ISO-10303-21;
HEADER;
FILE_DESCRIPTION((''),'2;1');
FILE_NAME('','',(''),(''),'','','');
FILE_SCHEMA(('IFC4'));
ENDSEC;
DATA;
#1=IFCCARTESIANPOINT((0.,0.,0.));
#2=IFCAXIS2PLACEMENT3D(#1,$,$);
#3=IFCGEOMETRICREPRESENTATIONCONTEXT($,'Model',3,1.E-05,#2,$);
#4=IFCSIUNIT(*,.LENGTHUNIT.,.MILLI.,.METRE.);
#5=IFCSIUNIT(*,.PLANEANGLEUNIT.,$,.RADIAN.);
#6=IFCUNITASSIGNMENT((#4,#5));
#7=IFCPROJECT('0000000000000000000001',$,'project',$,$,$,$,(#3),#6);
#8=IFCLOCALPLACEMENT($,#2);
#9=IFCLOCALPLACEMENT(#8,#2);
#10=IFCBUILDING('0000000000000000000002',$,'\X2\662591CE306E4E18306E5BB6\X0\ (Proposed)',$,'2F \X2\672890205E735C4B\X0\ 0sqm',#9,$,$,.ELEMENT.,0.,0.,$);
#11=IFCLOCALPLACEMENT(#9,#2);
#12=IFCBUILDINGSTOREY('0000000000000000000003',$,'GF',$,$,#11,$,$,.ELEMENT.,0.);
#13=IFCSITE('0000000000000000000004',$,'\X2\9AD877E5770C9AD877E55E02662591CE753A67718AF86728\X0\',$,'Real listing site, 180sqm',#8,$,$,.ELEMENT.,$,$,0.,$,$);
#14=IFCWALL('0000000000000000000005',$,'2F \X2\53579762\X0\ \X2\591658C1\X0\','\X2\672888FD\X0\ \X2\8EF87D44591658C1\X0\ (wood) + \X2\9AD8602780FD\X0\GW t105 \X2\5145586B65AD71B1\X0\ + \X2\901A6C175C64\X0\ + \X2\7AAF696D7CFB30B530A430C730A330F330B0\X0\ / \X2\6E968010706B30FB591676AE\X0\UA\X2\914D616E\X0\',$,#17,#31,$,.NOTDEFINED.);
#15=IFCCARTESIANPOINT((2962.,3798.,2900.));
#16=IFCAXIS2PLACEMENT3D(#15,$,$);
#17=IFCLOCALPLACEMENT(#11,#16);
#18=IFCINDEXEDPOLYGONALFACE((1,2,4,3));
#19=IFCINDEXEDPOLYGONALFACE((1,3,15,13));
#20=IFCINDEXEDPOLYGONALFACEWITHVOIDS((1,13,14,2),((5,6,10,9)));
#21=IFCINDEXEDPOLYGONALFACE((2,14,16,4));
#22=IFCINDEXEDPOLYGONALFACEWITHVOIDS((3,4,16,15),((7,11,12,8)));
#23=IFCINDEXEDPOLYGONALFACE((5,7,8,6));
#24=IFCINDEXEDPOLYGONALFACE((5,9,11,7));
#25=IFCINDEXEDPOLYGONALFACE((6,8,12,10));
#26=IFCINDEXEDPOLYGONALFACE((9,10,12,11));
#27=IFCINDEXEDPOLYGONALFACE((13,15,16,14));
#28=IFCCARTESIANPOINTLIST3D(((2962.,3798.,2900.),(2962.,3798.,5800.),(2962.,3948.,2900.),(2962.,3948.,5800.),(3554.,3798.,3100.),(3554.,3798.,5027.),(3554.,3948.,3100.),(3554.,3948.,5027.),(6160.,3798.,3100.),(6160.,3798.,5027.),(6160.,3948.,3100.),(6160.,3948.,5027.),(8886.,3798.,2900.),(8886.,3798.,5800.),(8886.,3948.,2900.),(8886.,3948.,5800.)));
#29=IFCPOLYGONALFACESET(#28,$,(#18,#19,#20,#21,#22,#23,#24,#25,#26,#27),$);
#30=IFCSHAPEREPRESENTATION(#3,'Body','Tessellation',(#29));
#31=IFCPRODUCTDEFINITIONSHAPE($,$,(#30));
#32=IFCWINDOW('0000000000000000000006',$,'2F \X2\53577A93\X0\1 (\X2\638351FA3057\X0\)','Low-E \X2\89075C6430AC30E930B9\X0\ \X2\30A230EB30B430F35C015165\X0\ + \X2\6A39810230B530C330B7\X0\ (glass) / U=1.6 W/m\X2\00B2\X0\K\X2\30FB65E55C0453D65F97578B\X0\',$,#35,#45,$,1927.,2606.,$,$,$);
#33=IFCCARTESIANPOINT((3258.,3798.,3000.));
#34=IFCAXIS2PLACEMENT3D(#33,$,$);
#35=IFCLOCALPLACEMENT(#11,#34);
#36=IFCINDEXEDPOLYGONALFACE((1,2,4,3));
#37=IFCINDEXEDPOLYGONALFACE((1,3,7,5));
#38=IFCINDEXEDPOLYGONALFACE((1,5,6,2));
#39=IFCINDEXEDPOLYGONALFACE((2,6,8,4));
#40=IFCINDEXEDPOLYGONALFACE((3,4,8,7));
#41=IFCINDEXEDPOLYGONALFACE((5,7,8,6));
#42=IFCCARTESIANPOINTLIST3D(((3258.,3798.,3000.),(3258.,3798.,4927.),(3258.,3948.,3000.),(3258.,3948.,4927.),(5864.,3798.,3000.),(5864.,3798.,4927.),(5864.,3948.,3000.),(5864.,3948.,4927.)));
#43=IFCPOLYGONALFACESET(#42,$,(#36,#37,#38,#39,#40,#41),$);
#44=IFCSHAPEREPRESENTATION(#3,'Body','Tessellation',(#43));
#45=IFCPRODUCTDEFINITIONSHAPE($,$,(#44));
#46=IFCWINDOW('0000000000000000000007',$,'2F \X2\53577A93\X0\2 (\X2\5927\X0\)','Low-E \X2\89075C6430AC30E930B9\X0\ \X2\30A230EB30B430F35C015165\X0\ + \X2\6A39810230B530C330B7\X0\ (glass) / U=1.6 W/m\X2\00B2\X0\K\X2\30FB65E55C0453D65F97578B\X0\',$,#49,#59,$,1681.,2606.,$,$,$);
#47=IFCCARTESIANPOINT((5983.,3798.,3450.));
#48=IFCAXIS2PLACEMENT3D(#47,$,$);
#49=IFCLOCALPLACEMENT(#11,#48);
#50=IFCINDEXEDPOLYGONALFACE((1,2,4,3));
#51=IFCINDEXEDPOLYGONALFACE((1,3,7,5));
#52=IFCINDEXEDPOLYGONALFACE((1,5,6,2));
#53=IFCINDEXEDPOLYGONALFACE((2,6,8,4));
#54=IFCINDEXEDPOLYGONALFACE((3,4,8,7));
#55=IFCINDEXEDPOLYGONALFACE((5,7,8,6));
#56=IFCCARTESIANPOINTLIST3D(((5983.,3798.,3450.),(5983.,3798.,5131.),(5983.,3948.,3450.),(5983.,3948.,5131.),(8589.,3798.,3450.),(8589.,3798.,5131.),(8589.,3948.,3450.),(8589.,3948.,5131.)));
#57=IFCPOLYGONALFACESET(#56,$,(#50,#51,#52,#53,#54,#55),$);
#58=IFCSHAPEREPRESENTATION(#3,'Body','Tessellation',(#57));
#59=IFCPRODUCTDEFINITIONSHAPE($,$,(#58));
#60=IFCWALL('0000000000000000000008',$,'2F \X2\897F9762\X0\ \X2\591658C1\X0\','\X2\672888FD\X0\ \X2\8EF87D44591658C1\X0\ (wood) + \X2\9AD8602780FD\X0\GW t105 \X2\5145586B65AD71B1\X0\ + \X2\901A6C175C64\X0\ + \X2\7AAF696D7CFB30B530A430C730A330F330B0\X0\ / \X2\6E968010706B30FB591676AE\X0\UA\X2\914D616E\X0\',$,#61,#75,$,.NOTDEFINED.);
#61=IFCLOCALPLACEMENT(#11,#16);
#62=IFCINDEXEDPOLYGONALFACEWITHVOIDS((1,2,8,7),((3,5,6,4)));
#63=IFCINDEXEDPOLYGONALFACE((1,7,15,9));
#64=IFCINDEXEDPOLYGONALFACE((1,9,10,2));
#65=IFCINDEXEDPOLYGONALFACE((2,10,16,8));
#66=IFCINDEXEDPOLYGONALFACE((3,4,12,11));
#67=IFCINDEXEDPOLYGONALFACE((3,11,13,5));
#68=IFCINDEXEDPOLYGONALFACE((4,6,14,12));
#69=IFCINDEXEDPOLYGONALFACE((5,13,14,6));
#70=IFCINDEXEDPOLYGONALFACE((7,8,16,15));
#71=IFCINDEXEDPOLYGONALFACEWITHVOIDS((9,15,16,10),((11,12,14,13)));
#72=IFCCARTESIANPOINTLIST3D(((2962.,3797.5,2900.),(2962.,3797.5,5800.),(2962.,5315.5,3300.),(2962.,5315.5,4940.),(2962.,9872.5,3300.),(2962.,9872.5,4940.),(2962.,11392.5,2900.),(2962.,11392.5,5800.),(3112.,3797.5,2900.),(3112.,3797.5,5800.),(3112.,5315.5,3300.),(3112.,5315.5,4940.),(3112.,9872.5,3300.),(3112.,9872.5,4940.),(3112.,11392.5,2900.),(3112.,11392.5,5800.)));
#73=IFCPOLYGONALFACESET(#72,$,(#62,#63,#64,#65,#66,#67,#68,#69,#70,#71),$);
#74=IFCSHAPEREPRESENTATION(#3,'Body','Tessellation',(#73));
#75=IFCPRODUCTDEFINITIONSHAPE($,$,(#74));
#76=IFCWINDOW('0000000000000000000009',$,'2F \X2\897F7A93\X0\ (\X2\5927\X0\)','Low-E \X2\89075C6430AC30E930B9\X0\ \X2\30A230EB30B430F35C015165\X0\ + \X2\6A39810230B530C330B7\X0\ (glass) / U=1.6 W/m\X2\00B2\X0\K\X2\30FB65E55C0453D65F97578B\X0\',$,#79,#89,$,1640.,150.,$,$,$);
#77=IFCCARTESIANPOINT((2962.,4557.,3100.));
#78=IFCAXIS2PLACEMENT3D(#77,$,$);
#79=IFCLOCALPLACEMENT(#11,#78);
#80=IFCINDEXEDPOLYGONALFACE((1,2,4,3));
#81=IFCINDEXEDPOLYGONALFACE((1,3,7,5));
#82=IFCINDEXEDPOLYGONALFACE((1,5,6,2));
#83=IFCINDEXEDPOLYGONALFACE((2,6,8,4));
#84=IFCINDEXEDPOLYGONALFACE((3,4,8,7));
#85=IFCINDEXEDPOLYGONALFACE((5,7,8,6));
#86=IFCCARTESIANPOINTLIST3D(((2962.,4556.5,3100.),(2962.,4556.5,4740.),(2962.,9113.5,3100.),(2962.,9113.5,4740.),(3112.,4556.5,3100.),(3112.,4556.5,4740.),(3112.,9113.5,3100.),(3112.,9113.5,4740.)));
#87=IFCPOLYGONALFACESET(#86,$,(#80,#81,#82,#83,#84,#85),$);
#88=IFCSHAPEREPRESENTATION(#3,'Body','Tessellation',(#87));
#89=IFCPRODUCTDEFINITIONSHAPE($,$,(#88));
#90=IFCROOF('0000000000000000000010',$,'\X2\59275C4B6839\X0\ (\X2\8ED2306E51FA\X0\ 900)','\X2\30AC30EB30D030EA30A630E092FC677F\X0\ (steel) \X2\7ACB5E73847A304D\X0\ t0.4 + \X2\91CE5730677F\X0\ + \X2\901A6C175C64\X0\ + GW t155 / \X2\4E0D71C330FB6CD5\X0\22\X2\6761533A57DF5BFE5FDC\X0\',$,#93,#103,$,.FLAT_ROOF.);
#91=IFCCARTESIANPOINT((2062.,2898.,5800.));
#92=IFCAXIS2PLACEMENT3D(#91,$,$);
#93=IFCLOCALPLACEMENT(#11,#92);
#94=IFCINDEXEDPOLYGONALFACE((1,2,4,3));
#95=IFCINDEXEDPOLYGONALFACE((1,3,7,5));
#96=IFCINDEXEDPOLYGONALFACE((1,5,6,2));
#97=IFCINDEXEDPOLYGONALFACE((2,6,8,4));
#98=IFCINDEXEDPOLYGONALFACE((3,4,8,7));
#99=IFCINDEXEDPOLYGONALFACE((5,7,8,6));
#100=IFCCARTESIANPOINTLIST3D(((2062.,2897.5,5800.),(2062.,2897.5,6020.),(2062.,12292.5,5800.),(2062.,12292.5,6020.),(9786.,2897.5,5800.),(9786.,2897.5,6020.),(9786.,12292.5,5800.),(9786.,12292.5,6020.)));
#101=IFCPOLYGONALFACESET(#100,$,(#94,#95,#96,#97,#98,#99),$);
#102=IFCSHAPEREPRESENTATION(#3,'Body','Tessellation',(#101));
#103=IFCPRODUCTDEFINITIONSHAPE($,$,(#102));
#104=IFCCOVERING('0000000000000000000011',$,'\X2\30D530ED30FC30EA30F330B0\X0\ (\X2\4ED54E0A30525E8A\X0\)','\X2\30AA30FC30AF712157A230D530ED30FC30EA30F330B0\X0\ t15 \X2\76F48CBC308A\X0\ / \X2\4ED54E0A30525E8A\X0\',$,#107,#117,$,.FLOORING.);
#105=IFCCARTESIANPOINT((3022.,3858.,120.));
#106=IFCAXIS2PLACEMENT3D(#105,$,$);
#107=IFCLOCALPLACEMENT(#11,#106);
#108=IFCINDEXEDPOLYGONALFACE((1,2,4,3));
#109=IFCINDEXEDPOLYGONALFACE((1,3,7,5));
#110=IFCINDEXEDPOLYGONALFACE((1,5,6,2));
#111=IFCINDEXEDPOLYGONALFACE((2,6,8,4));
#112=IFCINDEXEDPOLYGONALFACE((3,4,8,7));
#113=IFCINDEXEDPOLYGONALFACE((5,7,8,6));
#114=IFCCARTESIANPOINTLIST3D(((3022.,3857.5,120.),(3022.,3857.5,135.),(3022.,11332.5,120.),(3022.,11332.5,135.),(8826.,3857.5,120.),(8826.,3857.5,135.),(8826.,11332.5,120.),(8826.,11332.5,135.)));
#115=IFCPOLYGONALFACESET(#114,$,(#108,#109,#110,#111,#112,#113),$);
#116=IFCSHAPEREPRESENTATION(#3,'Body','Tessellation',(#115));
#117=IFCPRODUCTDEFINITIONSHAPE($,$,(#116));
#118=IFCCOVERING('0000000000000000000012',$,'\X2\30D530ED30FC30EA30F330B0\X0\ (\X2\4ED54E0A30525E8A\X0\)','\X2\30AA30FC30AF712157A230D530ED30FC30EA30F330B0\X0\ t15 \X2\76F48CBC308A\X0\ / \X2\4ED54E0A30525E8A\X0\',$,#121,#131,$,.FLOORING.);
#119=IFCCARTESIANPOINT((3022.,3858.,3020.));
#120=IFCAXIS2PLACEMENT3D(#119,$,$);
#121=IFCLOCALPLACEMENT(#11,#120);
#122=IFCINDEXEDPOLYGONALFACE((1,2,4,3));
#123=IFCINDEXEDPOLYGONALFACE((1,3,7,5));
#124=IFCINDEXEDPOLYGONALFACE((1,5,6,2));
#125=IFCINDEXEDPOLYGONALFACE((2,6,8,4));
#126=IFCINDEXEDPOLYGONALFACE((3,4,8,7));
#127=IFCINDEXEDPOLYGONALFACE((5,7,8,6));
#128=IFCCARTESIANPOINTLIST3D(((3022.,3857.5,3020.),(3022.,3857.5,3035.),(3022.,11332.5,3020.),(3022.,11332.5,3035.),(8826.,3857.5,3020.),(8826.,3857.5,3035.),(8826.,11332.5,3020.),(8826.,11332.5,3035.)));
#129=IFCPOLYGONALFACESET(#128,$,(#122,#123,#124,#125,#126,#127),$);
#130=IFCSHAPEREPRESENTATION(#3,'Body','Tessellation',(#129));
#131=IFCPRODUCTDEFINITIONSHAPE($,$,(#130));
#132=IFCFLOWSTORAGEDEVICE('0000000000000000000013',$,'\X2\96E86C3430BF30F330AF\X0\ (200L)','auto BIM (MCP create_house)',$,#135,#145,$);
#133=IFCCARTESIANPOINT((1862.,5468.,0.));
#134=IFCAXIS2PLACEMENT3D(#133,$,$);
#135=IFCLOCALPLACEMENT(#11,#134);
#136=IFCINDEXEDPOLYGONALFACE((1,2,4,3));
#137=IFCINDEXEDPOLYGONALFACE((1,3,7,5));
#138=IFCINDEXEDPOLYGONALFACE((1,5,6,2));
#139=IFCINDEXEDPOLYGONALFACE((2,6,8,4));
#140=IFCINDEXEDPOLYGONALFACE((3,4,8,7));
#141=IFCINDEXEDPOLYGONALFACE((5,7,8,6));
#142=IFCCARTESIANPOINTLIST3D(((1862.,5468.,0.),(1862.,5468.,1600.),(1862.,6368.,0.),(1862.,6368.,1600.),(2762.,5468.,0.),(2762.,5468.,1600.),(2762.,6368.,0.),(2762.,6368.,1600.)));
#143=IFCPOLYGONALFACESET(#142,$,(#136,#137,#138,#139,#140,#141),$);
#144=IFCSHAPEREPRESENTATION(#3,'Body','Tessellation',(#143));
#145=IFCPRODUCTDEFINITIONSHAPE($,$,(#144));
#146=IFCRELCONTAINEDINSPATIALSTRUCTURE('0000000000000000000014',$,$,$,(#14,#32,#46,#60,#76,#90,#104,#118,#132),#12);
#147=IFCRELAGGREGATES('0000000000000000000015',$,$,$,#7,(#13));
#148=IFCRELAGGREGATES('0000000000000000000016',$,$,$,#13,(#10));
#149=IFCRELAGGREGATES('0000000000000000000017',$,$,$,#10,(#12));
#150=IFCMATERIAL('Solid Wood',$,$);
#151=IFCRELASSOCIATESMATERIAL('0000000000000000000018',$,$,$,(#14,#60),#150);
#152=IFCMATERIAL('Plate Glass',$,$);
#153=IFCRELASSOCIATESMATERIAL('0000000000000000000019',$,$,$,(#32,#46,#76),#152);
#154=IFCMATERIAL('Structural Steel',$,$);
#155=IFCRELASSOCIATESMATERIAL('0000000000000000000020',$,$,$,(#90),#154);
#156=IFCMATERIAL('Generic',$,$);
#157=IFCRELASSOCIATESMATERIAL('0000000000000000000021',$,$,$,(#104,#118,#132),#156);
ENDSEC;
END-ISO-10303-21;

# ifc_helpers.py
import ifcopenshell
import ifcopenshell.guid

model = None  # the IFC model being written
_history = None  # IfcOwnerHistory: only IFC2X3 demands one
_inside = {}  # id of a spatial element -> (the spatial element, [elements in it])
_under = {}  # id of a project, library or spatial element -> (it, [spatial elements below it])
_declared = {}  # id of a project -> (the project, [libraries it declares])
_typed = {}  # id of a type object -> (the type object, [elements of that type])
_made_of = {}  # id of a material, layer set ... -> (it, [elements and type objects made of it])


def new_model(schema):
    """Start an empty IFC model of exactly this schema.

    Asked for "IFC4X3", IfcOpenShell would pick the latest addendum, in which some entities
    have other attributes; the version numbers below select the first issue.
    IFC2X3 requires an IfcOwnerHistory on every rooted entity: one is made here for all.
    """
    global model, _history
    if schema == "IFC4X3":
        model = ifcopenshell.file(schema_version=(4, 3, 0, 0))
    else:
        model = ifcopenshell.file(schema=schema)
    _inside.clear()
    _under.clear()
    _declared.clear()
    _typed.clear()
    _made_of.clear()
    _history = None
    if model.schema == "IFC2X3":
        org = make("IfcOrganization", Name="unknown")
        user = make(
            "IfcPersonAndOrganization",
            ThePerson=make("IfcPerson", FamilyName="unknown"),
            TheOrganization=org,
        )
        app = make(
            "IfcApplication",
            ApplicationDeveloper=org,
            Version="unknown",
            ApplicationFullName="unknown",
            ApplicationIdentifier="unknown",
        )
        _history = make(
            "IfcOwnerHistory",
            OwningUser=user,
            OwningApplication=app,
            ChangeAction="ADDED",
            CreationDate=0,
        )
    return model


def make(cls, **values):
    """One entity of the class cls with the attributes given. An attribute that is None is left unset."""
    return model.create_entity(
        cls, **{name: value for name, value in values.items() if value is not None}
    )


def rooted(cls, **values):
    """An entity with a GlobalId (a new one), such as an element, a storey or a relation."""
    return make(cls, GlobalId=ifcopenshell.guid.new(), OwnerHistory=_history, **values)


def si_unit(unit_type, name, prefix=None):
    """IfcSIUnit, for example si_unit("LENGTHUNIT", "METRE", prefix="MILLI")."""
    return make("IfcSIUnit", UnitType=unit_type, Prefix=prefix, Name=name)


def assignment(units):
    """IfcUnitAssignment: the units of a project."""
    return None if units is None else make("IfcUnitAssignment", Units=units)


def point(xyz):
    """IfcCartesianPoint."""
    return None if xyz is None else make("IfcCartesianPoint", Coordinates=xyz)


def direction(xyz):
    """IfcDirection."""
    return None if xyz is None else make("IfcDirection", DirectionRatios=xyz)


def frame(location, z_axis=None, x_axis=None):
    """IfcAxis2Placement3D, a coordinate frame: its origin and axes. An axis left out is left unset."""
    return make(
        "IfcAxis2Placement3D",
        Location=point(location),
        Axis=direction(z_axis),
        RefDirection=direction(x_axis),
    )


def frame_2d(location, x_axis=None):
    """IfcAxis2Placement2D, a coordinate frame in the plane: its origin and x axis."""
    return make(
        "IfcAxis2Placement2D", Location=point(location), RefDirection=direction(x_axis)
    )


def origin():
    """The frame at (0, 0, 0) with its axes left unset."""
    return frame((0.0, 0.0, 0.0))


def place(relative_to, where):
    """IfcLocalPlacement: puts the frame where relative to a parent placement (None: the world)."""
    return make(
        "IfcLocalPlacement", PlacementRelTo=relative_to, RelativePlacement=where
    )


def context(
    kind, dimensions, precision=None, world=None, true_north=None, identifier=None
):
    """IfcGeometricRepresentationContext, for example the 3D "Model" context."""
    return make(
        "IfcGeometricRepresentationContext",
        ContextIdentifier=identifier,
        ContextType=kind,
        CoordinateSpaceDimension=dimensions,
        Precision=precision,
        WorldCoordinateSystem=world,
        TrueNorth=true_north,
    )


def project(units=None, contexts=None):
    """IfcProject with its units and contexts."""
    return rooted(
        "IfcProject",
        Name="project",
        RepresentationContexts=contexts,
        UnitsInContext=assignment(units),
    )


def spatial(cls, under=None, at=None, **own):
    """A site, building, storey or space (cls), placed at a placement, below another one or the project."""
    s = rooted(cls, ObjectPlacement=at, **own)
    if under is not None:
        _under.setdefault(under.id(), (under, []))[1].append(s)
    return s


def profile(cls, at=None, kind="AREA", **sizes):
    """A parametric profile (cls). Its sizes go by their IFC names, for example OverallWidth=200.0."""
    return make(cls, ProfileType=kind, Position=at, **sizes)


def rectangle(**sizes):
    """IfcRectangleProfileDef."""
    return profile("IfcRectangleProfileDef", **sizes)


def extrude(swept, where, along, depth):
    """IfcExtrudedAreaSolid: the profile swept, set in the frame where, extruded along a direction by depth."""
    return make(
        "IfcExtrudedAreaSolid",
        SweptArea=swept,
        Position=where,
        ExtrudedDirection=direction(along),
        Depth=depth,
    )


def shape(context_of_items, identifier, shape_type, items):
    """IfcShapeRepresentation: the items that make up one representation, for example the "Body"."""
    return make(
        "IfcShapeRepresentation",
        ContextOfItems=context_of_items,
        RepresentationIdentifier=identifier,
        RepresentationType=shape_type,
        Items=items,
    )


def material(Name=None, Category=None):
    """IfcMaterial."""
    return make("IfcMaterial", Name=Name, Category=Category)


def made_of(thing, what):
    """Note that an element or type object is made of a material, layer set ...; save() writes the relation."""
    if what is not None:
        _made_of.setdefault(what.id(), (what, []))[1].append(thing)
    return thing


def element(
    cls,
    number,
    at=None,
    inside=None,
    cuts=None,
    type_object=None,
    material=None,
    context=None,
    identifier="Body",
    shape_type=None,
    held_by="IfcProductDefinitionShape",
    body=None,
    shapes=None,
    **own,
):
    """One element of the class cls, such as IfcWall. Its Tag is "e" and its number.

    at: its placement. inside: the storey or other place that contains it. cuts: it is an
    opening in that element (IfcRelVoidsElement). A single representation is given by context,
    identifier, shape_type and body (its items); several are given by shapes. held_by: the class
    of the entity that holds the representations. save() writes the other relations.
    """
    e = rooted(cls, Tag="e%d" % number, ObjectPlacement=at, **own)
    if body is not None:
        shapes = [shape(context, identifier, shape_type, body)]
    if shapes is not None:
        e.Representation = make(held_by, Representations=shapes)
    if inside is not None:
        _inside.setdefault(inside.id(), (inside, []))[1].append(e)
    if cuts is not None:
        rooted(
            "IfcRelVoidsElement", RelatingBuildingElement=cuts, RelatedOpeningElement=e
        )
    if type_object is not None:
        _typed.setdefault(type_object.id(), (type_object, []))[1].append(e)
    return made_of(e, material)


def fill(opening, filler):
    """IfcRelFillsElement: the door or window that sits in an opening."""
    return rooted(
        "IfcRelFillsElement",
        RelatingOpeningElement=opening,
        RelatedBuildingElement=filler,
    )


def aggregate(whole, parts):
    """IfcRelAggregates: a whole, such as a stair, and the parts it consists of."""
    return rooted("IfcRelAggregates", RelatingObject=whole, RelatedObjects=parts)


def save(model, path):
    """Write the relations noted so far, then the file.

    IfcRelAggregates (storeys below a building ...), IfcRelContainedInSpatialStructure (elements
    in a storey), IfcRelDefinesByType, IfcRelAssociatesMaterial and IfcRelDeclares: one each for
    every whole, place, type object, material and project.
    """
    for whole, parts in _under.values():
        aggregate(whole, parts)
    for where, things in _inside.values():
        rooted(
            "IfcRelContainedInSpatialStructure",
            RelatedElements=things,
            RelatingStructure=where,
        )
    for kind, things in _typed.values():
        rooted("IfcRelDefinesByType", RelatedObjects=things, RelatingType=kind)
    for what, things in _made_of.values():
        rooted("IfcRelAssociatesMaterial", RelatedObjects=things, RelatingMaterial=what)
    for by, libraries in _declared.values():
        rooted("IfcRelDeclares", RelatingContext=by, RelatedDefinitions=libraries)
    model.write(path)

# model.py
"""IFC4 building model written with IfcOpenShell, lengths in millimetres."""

from ifc_helpers import new_model, si_unit, frame, frame_2d, origin, place, context, project, spatial, rectangle, extrude, material, element, fill, save


model = new_model("IFC4")

# Units and contexts
model_context = context("Model", 3, precision=1e-05, world=origin())
ifc_project = project(units=[si_unit("LENGTHUNIT", "METRE", prefix="MILLI"), si_unit("PLANEANGLEUNIT", "RADIAN")], contexts=[model_context])

# Site, building, storey
site_placement = place(None, origin())
site = spatial("IfcSite", under=ifc_project, at=site_placement, Name="高知県高知市春野町東諸木", ObjectType="Real listing site, 180sqm", CompositionType="ELEMENT", RefElevation=0.0)
building_placement = place(site_placement, origin())
building = spatial("IfcBuilding", under=site, at=building_placement, Name="春野の丘の家 (Proposed)", ObjectType="2F 木造平屋 0sqm", CompositionType="ELEMENT", ElevationOfRefHeight=0.0, ElevationOfTerrain=0.0)
storey_placement = place(building_placement, origin())
storey = spatial("IfcBuildingStorey", under=building, at=storey_placement, Name="GF", CompositionType="ELEMENT", Elevation=0.0)

# Shared definitions
ifc_material_1 = material(Name="Solid Wood")

# Shared definitions
ifc_material_2 = material(Name="Plate Glass")

# Wall, openings, windows
wall_1_placement = place(storey_placement, frame((2962.0, 3798.0, 2900.0)))
wall_1 = element("IfcWall", 1, at=wall_1_placement, inside=storey, material=ifc_material_1, Name="2F 南面 外壁", Description="木製 軸組外壁 (wood) + 高性能GW t105 充填断熱 + 通気層 + 窯業系サイディング / 準耐火・外皮UA配慮", PredefinedType="NOTDEFINED", context=model_context, shape_type="SweptSolid", body=[
    extrude(rectangle(XDim=5924.0, YDim=150.0, at=frame_2d((2962.0, 75.0))), frame((2962.0, 3798.0, 2900.0)), (0.0, 0.0, 1.0), 2900.0),
])
opening_1_placement = place(storey_placement, frame((3258.0, 3798.0, 3000.0)))
opening_1 = element("IfcOpeningElement", 2, at=opening_1_placement, cuts=wall_1, PredefinedType="NOTDEFINED", context=model_context, shape_type="SweptSolid", body=[
    extrude(rectangle(XDim=2606.0, YDim=150.0, at=frame_2d((1303.0, 75.0))), frame((3258.0, 3798.0, 3000.0)), (0.0, 0.0, 1.0), 1927.0),
])
opening_2_placement = place(storey_placement, frame((5983.0, 3798.0, 3450.0)))
opening_2 = element("IfcOpeningElement", 3, at=opening_2_placement, cuts=wall_1, PredefinedType="NOTDEFINED", context=model_context, shape_type="SweptSolid", body=[
    extrude(rectangle(XDim=2606.0, YDim=150.0, at=frame_2d((1303.0, 75.0))), frame((5983.0, 3798.0, 3450.0)), (0.0, 0.0, 1.0), 1681.0),
])
window_1_placement = place(storey_placement, frame((3258.0, 3798.0, 3000.0)))
window_1 = element("IfcWindow", 4, at=window_1_placement, inside=storey, material=ifc_material_2, Name="2F 南窓1 (掃出し)", Description="Low-E 複層ガラス アルゴン封入 + 樹脂サッシ (glass) / U=1.6 W/m²K・日射取得型", OverallHeight=1927.0, OverallWidth=2606.0, context=model_context, shape_type="SweptSolid", body=[
    extrude(rectangle(XDim=2606.0, YDim=150.0, at=frame_2d((1303.0, 75.0))), frame((3258.0, 3798.0, 3000.0)), (0.0, 0.0, 1.0), 1927.0),
])
fill(opening_1, window_1)
window_2_placement = place(storey_placement, frame((5983.0, 3798.0, 3450.0)))
window_2 = element("IfcWindow", 5, at=window_2_placement, inside=storey, material=ifc_material_2, Name="2F 南窓2 (大)", Description="Low-E 複層ガラス アルゴン封入 + 樹脂サッシ (glass) / U=1.6 W/m²K・日射取得型", OverallHeight=1681.0, OverallWidth=2606.0, context=model_context, shape_type="SweptSolid", body=[
    extrude(rectangle(XDim=2606.0, YDim=150.0, at=frame_2d((1303.0, 75.0))), frame((5983.0, 3798.0, 3450.0)), (0.0, 0.0, 1.0), 1681.0),
])
fill(opening_2, window_2)

# Wall, opening, window
wall_2_placement = place(storey_placement, frame((2962.0, 3798.0, 2900.0)))
wall_2 = element("IfcWall", 6, at=wall_2_placement, inside=storey, material=ifc_material_1, Name="2F 西面 外壁", Description="木製 軸組外壁 (wood) + 高性能GW t105 充填断熱 + 通気層 + 窯業系サイディング / 準耐火・外皮UA配慮", PredefinedType="NOTDEFINED", context=model_context, shape_type="SweptSolid", body=[
    extrude(rectangle(XDim=150.0, YDim=7595.0, at=frame_2d((75.0, 3797.0))), frame((2962.0, 3798.0, 2900.0)), (0.0, 0.0, 1.0), 2900.0),
])
opening_3_placement = place(storey_placement, frame((2962.0, 4557.0, 3100.0)))
opening_3 = element("IfcOpeningElement", 7, at=opening_3_placement, cuts=wall_2, PredefinedType="NOTDEFINED", context=model_context, shape_type="SweptSolid", body=[
    extrude(rectangle(XDim=150.0, YDim=4557.0, at=frame_2d((75.0, 2278.0))), frame((2962.0, 4557.0, 3100.0)), (0.0, 0.0, 1.0), 1640.0),
])
window_3_placement = place(storey_placement, frame((2962.0, 4557.0, 3100.0)))
window_3 = element("IfcWindow", 8, at=window_3_placement, inside=storey, material=ifc_material_2, Name="2F 西窓 (大)", Description="Low-E 複層ガラス アルゴン封入 + 樹脂サッシ (glass) / U=1.6 W/m²K・日射取得型", OverallHeight=1640.0, OverallWidth=150.0, context=model_context, shape_type="SweptSolid", body=[
    extrude(rectangle(XDim=150.0, YDim=4557.0, at=frame_2d((75.0, 2278.0))), frame((2962.0, 4557.0, 3100.0)), (0.0, 0.0, 1.0), 1640.0),
])
fill(opening_3, window_3)

# Roof
ifc_material_3 = material(Name="Structural Steel")
roof_placement = place(storey_placement, frame((2062.0, 2898.0, 5800.0)))
element("IfcRoof", 9, at=roof_placement, inside=storey, material=ifc_material_3, Name="大屋根 (軒の出 900)", Description="ガルバリウム鋼板 (steel) 立平葺き t0.4 + 野地板 + 通気層 + GW t155 / 不燃・法22条区域対応", PredefinedType="FLAT_ROOF", context=model_context, shape_type="SweptSolid", body=[
    extrude(rectangle(XDim=7724.0, YDim=9395.0, at=frame_2d((3862.0, 4697.0))), frame((2062.0, 2898.0, 5800.0)), (0.0, 0.0, 1.0), 220.0),
])

# Coverings
ifc_material_4 = material(Name="Generic")
covering_1_placement = place(storey_placement, frame((3022.0, 3858.0, 120.0)))
element("IfcCovering", 10, at=covering_1_placement, inside=storey, material=ifc_material_4, Name="フローリング (仕上げ床)", Description="オーク無垢フローリング t15 直貼り / 仕上げ床", PredefinedType="FLOORING", context=model_context, shape_type="SweptSolid", body=[
    extrude(rectangle(XDim=5804.0, YDim=7475.0, at=frame_2d((2902.0, 3737.0))), frame((3022.0, 3858.0, 120.0)), (0.0, 0.0, 1.0), 15.0),
])
covering_2_placement = place(storey_placement, frame((3022.0, 3858.0, 3020.0)))
element("IfcCovering", 11, at=covering_2_placement, inside=storey, material=ifc_material_4, Name="フローリング (仕上げ床)", Description="オーク無垢フローリング t15 直貼り / 仕上げ床", PredefinedType="FLOORING", context=model_context, shape_type="SweptSolid", body=[
    extrude(rectangle(XDim=5804.0, YDim=7475.0, at=frame_2d((2902.0, 3737.0))), frame((3022.0, 3858.0, 3020.0)), (0.0, 0.0, 1.0), 15.0),
])

# Flow storage device
flow_storage_device_placement = place(storey_placement, frame((1862.0, 5468.0, 0.0)))
element("IfcFlowStorageDevice", 12, at=flow_storage_device_placement, inside=storey, material=ifc_material_4, Name="雨水タンク (200L)", Description="auto BIM (MCP create_house)", context=model_context, shape_type="SweptSolid", body=[
    extrude(rectangle(XDim=900.0, YDim=900.0, at=frame_2d((450.0, 450.0))), frame((1862.0, 5468.0, 0.0)), (0.0, 0.0, 1.0), 1600.0),
])

save(model, "model.ifc")
